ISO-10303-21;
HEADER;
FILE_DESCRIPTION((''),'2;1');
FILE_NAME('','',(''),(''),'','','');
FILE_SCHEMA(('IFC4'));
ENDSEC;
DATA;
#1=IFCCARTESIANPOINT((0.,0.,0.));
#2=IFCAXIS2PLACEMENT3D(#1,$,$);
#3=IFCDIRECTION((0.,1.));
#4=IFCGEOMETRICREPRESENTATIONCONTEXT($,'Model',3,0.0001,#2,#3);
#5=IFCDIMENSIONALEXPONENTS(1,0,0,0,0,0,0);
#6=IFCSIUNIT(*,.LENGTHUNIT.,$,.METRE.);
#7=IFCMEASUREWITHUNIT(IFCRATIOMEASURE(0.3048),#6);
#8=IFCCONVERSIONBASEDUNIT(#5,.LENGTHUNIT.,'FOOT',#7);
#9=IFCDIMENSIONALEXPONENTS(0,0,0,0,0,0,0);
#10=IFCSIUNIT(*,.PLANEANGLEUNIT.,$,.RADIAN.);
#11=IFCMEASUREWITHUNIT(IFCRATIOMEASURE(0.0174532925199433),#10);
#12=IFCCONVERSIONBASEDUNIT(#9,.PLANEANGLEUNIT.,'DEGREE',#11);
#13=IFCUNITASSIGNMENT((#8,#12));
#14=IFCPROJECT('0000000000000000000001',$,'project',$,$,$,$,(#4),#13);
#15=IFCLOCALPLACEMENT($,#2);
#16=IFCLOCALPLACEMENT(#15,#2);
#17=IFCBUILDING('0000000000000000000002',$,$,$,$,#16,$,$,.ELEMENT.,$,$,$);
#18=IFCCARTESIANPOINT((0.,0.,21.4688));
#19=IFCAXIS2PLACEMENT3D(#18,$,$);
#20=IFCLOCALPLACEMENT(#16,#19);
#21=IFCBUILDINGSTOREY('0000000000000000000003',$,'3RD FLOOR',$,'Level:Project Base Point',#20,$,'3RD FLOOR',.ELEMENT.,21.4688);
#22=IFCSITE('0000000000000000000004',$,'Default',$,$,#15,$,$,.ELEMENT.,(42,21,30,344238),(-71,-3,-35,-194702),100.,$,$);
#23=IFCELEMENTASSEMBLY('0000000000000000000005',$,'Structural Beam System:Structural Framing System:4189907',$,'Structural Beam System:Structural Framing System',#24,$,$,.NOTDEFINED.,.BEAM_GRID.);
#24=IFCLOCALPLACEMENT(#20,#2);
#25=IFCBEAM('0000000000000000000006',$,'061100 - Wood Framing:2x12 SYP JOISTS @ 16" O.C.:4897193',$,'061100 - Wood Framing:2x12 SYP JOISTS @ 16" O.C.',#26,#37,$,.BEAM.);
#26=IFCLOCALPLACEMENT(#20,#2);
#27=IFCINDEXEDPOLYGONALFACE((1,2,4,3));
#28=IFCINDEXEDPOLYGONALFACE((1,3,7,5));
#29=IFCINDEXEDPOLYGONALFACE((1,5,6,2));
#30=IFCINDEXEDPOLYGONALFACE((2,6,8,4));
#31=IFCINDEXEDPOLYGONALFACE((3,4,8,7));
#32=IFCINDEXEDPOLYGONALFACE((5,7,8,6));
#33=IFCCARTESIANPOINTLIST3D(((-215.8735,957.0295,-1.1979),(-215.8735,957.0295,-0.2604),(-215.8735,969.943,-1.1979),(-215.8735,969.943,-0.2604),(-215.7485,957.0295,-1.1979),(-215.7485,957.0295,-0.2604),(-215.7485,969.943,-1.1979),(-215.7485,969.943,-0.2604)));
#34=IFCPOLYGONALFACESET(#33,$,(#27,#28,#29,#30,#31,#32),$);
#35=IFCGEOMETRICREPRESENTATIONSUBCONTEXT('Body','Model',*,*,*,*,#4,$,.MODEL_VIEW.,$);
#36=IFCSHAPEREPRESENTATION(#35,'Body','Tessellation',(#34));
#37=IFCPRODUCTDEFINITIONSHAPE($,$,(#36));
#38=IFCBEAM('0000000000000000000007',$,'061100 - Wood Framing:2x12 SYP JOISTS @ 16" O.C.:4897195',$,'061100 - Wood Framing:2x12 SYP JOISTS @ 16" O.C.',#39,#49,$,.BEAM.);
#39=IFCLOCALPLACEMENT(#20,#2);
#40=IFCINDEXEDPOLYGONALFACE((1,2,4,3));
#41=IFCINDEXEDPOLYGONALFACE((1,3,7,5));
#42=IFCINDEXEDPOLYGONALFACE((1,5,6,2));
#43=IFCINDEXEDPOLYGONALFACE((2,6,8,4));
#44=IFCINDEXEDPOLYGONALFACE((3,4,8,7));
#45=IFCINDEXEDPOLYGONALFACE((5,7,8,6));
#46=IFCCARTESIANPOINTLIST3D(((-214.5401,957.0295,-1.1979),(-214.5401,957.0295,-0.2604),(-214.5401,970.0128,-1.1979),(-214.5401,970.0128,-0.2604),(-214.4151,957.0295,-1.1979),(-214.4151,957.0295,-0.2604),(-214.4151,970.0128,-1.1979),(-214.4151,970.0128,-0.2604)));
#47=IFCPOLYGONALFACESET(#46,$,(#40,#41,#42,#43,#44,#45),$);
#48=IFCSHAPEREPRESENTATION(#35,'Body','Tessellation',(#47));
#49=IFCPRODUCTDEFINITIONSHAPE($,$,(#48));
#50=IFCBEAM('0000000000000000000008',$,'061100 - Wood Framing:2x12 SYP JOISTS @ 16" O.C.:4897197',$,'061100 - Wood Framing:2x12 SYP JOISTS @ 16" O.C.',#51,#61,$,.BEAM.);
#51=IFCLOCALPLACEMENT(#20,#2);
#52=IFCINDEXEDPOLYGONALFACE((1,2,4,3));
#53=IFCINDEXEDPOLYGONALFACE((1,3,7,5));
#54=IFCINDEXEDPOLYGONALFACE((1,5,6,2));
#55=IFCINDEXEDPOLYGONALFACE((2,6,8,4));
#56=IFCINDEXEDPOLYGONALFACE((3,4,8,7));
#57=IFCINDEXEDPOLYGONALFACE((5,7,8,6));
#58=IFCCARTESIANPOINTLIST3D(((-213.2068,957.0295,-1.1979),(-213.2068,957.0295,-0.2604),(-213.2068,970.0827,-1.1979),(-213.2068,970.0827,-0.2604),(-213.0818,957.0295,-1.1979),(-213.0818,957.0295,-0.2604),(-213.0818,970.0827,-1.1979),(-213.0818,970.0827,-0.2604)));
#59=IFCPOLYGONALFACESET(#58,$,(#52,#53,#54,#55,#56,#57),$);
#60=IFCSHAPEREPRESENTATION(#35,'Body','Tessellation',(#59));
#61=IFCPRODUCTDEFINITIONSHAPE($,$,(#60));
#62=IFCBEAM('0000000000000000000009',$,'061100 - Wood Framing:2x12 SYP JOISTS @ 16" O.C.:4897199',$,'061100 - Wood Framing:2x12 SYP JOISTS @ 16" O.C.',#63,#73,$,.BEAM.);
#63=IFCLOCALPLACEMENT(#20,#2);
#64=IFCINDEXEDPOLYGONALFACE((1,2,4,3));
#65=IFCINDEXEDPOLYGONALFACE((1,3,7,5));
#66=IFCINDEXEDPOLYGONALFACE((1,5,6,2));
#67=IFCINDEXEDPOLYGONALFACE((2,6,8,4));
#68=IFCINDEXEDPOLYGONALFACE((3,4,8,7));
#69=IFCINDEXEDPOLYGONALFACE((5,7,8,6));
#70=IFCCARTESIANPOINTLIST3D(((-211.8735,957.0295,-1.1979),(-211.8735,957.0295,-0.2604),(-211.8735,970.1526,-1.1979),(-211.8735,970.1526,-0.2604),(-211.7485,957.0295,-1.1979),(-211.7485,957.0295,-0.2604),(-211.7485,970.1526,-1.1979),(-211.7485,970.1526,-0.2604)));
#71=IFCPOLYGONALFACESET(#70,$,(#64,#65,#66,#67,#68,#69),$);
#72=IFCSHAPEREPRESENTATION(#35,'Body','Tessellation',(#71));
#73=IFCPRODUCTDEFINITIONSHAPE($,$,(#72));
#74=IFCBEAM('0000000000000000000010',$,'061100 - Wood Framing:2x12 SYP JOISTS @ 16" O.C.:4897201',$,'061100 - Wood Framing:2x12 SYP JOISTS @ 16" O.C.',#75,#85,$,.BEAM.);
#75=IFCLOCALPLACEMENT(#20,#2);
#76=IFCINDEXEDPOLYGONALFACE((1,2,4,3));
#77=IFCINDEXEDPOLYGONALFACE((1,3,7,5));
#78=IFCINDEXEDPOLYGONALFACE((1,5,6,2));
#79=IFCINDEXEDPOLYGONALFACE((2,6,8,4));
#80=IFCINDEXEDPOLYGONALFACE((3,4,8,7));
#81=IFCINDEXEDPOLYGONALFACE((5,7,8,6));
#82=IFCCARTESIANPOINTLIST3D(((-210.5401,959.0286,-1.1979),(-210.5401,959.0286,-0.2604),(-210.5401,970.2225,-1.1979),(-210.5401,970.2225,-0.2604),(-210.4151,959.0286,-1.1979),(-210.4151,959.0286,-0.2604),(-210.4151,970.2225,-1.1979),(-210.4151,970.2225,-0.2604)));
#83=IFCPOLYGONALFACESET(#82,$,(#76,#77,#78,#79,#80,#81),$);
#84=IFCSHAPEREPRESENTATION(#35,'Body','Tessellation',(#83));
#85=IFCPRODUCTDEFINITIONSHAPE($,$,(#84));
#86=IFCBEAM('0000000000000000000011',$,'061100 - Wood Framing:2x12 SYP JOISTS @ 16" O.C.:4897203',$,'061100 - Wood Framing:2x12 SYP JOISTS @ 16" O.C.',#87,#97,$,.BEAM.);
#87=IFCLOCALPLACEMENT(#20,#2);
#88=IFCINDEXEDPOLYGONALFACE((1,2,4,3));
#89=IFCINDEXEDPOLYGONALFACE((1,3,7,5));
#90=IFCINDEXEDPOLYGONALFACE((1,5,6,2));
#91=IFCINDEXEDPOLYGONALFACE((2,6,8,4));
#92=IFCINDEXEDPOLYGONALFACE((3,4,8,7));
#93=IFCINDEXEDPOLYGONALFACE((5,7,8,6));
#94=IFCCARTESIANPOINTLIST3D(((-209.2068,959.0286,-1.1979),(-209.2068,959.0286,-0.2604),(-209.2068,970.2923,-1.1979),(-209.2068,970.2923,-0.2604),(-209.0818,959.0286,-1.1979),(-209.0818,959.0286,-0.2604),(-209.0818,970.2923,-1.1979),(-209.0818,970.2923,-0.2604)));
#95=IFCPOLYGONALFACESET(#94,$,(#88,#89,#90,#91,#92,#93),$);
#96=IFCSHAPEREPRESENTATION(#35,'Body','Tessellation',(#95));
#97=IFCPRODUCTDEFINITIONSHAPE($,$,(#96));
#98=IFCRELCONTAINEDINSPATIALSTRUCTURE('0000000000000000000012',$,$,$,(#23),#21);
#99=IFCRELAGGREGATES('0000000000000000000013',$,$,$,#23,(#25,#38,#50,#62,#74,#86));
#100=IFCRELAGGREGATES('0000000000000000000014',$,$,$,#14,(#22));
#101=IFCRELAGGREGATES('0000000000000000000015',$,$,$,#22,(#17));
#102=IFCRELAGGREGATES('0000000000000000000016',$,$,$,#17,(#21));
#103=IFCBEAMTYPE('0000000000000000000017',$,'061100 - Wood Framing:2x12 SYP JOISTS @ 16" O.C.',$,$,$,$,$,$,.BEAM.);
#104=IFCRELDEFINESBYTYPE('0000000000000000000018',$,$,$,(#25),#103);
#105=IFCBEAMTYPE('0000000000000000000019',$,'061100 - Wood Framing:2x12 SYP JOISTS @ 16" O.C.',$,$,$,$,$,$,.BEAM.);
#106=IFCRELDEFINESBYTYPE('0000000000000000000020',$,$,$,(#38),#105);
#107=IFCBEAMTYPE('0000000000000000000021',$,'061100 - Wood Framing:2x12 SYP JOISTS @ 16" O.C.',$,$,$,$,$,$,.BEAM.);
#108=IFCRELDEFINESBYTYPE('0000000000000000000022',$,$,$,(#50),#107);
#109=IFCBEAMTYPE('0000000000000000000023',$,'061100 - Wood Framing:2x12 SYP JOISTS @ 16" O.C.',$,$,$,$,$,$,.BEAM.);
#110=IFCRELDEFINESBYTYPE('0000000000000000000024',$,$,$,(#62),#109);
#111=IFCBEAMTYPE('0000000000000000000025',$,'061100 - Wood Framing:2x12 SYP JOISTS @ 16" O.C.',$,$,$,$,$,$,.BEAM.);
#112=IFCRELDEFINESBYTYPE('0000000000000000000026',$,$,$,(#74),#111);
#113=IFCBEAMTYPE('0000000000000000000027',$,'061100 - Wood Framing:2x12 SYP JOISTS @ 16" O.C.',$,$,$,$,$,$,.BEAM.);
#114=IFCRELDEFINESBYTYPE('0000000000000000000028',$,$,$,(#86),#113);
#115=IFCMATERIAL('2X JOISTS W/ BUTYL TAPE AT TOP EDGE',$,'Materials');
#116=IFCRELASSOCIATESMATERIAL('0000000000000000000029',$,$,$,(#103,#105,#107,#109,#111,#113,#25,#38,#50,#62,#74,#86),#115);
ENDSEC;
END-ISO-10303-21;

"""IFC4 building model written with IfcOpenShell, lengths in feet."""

from ifc_helpers import new_model, entity, si_unit, converted_unit, direction, frame, origin, origin_2d_with_axis, place, context, subcontext, project, spatial, rectangle, extrude, source, transform, mapped, material, material_profile, profile_set, profile_usage, type_object, type_shapes, element, aggregate, save


model = new_model("IFC4")

# Units and contexts
model_context = context("Model", 3, precision=0.0001, world=origin(), true_north=direction((0.0, 1.0)))
body_context = subcontext(model_context, "Body", "Model", "MODEL_VIEW")
ifc_project = project(units=[converted_unit("LENGTHUNIT", "FOOT", entity("IfcRatioMeasure", 0.3048), si_unit("LENGTHUNIT", "METRE"), dimensions=[1, 0, 0, 0, 0, 0, 0]), converted_unit("PLANEANGLEUNIT", "DEGREE", entity("IfcRatioMeasure", 0.0174532925199433), si_unit("PLANEANGLEUNIT", "RADIAN"), dimensions=[0, 0, 0, 0, 0, 0, 0])], contexts=[model_context])

# Site, building, storey
site_placement = place(None, origin())
site = spatial("IfcSite", under=ifc_project, at=site_placement, Name="Default", CompositionType="ELEMENT", RefLatitude=(42, 21, 30, 344238), RefLongitude=(-71, -3, -35, -194702), RefElevation=100.0)
building_placement = place(site_placement, origin())
building = spatial("IfcBuilding", under=site, at=building_placement, CompositionType="ELEMENT")
storey_placement = place(building_placement, frame((0.0, 0.0, 21.4688)))
storey = spatial("IfcBuildingStorey", under=building, at=storey_placement, Name="3RD FLOOR", ObjectType="Level:Project Base Point", LongName="3RD FLOOR", CompositionType="ELEMENT", Elevation=21.4688)

# Element assembly, beams
assembly_1_placement = place(storey_placement, origin())
assembly_1 = element("IfcElementAssembly", 1, at=assembly_1_placement, inside=storey, Name="Structural Beam System:Structural Framing System:4189907", ObjectType="Structural Beam System:Structural Framing System", AssemblyPlace="NOTDEFINED", PredefinedType="BEAM_GRID")
ifc_material_1 = material(Name="2X JOISTS W/ BUTYL TAPE AT TOP EDGE", Category="Materials")
ifc_material_profile_1 = material_profile(ifc_material_1, rectangle(XDim=0.9375, YDim=0.125, at=origin_2d_with_axis()), Name="2x12 SYP JOISTS @ 16\" O.C.")
ifc_profile_set_1 = profile_set([ifc_material_profile_1], Name="2x12 SYP JOISTS @ 16\" O.C.")
ifc_profile_usage_1 = profile_usage(ifc_profile_set_1, cardinal=8)
beam_type_1 = type_object("IfcBeamType", Name="061100 - Wood Framing:2x12 SYP JOISTS @ 16\" O.C.", PredefinedType="BEAM", material=ifc_profile_set_1)
shared_shape_1 = source(origin(), body_context, "Body", "SweptSolid", [
    extrude(rectangle(XDim=0.9375, YDim=0.125, at=origin_2d_with_axis()), frame((-6.4567, 0.0, 0.0), z_axis=(1.0, 0.0, 0.0), x_axis=(0.0, 0.0, -1.0)), (0.0, 0.0, 1.0), 12.9134),
])
type_shapes(beam_type_1, [shared_shape_1])
beam_1_placement = place(assembly_1_placement, frame((-215.811, 963.4862, -0.7292), z_axis=(0.0, 0.0, 1.0), x_axis=(0.0, 1.0, 0.0)))
beam_1 = element("IfcBeam", 2, at=beam_1_placement, type_object=beam_type_1, material=ifc_profile_usage_1, Name="061100 - Wood Framing:2x12 SYP JOISTS @ 16\" O.C.:4897193", ObjectType="061100 - Wood Framing:2x12 SYP JOISTS @ 16\" O.C.", PredefinedType="BEAM", context=body_context, shape_type="MappedRepresentation", body=[
    mapped(shared_shape_1, transform((0.0, 0.0, 0.0), scale=1.0)),
])
ifc_profile_usage_2 = profile_usage(ifc_profile_set_1, cardinal=8)
beam_type_2 = type_object("IfcBeamType", Name="061100 - Wood Framing:2x12 SYP JOISTS @ 16\" O.C.", PredefinedType="BEAM", material=ifc_profile_set_1)
shared_shape_2 = source(origin(), body_context, "Body", "SweptSolid", [
    extrude(rectangle(XDim=0.9375, YDim=0.125, at=origin_2d_with_axis()), frame((-6.4917, 0.0, 0.0), z_axis=(1.0, 0.0, 0.0), x_axis=(0.0, 0.0, -1.0)), (0.0, 0.0, 1.0), 12.9833),
])
type_shapes(beam_type_2, [shared_shape_2])
beam_2_placement = place(assembly_1_placement, frame((-214.4776, 963.5212, -0.7292), z_axis=(0.0, 0.0, 1.0), x_axis=(0.0, 1.0, 0.0)))
beam_2 = element("IfcBeam", 3, at=beam_2_placement, type_object=beam_type_2, material=ifc_profile_usage_2, Name="061100 - Wood Framing:2x12 SYP JOISTS @ 16\" O.C.:4897195", ObjectType="061100 - Wood Framing:2x12 SYP JOISTS @ 16\" O.C.", PredefinedType="BEAM", context=body_context, shape_type="MappedRepresentation", body=[
    mapped(shared_shape_2, transform((0.0, 0.0, 0.0), scale=1.0)),
])
ifc_profile_usage_3 = profile_usage(ifc_profile_set_1, cardinal=8)
beam_type_3 = type_object("IfcBeamType", Name="061100 - Wood Framing:2x12 SYP JOISTS @ 16\" O.C.", PredefinedType="BEAM", material=ifc_profile_set_1)
shared_shape_3 = source(origin(), body_context, "Body", "SweptSolid", [
    extrude(rectangle(XDim=0.9375, YDim=0.125, at=origin_2d_with_axis()), frame((-6.5266, 0.0, 0.0), z_axis=(1.0, 0.0, 0.0), x_axis=(0.0, 0.0, -1.0)), (0.0, 0.0, 1.0), 13.0532),
])
type_shapes(beam_type_3, [shared_shape_3])
beam_3_placement = place(assembly_1_placement, frame((-213.1443, 963.5561, -0.7292), z_axis=(0.0, 0.0, 1.0), x_axis=(0.0, 1.0, 0.0)))
beam_3 = element("IfcBeam", 4, at=beam_3_placement, type_object=beam_type_3, material=ifc_profile_usage_3, Name="061100 - Wood Framing:2x12 SYP JOISTS @ 16\" O.C.:4897197", ObjectType="061100 - Wood Framing:2x12 SYP JOISTS @ 16\" O.C.", PredefinedType="BEAM", context=body_context, shape_type="MappedRepresentation", body=[
    mapped(shared_shape_3, transform((0.0, 0.0, 0.0), scale=1.0)),
])
ifc_profile_usage_4 = profile_usage(ifc_profile_set_1, cardinal=8)
beam_type_4 = type_object("IfcBeamType", Name="061100 - Wood Framing:2x12 SYP JOISTS @ 16\" O.C.", PredefinedType="BEAM", material=ifc_profile_set_1)
shared_shape_4 = source(origin(), body_context, "Body", "SweptSolid", [
    extrude(rectangle(XDim=0.9375, YDim=0.125, at=origin_2d_with_axis()), frame((-6.5615, 0.0, 0.0), z_axis=(1.0, 0.0, 0.0), x_axis=(0.0, 0.0, -1.0)), (0.0, 0.0, 1.0), 13.1231),
])
type_shapes(beam_type_4, [shared_shape_4])
beam_4_placement = place(assembly_1_placement, frame((-211.811, 963.591, -0.7292), z_axis=(0.0, 0.0, 1.0), x_axis=(0.0, 1.0, 0.0)))
beam_4 = element("IfcBeam", 5, at=beam_4_placement, type_object=beam_type_4, material=ifc_profile_usage_4, Name="061100 - Wood Framing:2x12 SYP JOISTS @ 16\" O.C.:4897199", ObjectType="061100 - Wood Framing:2x12 SYP JOISTS @ 16\" O.C.", PredefinedType="BEAM", context=body_context, shape_type="MappedRepresentation", body=[
    mapped(shared_shape_4, transform((0.0, 0.0, 0.0), scale=1.0)),
])
ifc_profile_usage_5 = profile_usage(ifc_profile_set_1, cardinal=8)
beam_type_5 = type_object("IfcBeamType", Name="061100 - Wood Framing:2x12 SYP JOISTS @ 16\" O.C.", PredefinedType="BEAM", material=ifc_profile_set_1)
shared_shape_5 = source(origin(), body_context, "Body", "SweptSolid", [
    extrude(rectangle(XDim=0.9375, YDim=0.125, at=origin_2d_with_axis()), frame((-5.5969, 0.0, 0.0), z_axis=(1.0, 0.0, 0.0), x_axis=(0.0, 0.0, -1.0)), (0.0, 0.0, 1.0), 11.1939),
])
type_shapes(beam_type_5, [shared_shape_5])
beam_5_placement = place(assembly_1_placement, frame((-210.4776, 964.6255, -0.7292), z_axis=(0.0, 0.0, 1.0), x_axis=(0.0, 1.0, 0.0)))
beam_5 = element("IfcBeam", 6, at=beam_5_placement, type_object=beam_type_5, material=ifc_profile_usage_5, Name="061100 - Wood Framing:2x12 SYP JOISTS @ 16\" O.C.:4897201", ObjectType="061100 - Wood Framing:2x12 SYP JOISTS @ 16\" O.C.", PredefinedType="BEAM", context=body_context, shape_type="MappedRepresentation", body=[
    mapped(shared_shape_5, transform((0.0, 0.0, 0.0), scale=1.0)),
])
ifc_profile_usage_6 = profile_usage(ifc_profile_set_1, cardinal=8)
beam_type_6 = type_object("IfcBeamType", Name="061100 - Wood Framing:2x12 SYP JOISTS @ 16\" O.C.", PredefinedType="BEAM", material=ifc_profile_set_1)
shared_shape_6 = source(origin(), body_context, "Body", "SweptSolid", [
    extrude(rectangle(XDim=0.9375, YDim=0.125, at=origin_2d_with_axis()), frame((-5.6319, 0.0, 0.0), z_axis=(1.0, 0.0, 0.0), x_axis=(0.0, 0.0, -1.0)), (0.0, 0.0, 1.0), 11.2637),
])
type_shapes(beam_type_6, [shared_shape_6])
beam_6_placement = place(assembly_1_placement, frame((-209.1443, 964.6605, -0.7292), z_axis=(0.0, 0.0, 1.0), x_axis=(0.0, 1.0, 0.0)))
beam_6 = element("IfcBeam", 7, at=beam_6_placement, type_object=beam_type_6, material=ifc_profile_usage_6, Name="061100 - Wood Framing:2x12 SYP JOISTS @ 16\" O.C.:4897203", ObjectType="061100 - Wood Framing:2x12 SYP JOISTS @ 16\" O.C.", PredefinedType="BEAM", context=body_context, shape_type="MappedRepresentation", body=[
    mapped(shared_shape_6, transform((0.0, 0.0, 0.0), scale=1.0)),
])
aggregate(assembly_1, [beam_1, beam_2, beam_3, beam_4, beam_5, beam_6])

save(model, "model.ifc")
